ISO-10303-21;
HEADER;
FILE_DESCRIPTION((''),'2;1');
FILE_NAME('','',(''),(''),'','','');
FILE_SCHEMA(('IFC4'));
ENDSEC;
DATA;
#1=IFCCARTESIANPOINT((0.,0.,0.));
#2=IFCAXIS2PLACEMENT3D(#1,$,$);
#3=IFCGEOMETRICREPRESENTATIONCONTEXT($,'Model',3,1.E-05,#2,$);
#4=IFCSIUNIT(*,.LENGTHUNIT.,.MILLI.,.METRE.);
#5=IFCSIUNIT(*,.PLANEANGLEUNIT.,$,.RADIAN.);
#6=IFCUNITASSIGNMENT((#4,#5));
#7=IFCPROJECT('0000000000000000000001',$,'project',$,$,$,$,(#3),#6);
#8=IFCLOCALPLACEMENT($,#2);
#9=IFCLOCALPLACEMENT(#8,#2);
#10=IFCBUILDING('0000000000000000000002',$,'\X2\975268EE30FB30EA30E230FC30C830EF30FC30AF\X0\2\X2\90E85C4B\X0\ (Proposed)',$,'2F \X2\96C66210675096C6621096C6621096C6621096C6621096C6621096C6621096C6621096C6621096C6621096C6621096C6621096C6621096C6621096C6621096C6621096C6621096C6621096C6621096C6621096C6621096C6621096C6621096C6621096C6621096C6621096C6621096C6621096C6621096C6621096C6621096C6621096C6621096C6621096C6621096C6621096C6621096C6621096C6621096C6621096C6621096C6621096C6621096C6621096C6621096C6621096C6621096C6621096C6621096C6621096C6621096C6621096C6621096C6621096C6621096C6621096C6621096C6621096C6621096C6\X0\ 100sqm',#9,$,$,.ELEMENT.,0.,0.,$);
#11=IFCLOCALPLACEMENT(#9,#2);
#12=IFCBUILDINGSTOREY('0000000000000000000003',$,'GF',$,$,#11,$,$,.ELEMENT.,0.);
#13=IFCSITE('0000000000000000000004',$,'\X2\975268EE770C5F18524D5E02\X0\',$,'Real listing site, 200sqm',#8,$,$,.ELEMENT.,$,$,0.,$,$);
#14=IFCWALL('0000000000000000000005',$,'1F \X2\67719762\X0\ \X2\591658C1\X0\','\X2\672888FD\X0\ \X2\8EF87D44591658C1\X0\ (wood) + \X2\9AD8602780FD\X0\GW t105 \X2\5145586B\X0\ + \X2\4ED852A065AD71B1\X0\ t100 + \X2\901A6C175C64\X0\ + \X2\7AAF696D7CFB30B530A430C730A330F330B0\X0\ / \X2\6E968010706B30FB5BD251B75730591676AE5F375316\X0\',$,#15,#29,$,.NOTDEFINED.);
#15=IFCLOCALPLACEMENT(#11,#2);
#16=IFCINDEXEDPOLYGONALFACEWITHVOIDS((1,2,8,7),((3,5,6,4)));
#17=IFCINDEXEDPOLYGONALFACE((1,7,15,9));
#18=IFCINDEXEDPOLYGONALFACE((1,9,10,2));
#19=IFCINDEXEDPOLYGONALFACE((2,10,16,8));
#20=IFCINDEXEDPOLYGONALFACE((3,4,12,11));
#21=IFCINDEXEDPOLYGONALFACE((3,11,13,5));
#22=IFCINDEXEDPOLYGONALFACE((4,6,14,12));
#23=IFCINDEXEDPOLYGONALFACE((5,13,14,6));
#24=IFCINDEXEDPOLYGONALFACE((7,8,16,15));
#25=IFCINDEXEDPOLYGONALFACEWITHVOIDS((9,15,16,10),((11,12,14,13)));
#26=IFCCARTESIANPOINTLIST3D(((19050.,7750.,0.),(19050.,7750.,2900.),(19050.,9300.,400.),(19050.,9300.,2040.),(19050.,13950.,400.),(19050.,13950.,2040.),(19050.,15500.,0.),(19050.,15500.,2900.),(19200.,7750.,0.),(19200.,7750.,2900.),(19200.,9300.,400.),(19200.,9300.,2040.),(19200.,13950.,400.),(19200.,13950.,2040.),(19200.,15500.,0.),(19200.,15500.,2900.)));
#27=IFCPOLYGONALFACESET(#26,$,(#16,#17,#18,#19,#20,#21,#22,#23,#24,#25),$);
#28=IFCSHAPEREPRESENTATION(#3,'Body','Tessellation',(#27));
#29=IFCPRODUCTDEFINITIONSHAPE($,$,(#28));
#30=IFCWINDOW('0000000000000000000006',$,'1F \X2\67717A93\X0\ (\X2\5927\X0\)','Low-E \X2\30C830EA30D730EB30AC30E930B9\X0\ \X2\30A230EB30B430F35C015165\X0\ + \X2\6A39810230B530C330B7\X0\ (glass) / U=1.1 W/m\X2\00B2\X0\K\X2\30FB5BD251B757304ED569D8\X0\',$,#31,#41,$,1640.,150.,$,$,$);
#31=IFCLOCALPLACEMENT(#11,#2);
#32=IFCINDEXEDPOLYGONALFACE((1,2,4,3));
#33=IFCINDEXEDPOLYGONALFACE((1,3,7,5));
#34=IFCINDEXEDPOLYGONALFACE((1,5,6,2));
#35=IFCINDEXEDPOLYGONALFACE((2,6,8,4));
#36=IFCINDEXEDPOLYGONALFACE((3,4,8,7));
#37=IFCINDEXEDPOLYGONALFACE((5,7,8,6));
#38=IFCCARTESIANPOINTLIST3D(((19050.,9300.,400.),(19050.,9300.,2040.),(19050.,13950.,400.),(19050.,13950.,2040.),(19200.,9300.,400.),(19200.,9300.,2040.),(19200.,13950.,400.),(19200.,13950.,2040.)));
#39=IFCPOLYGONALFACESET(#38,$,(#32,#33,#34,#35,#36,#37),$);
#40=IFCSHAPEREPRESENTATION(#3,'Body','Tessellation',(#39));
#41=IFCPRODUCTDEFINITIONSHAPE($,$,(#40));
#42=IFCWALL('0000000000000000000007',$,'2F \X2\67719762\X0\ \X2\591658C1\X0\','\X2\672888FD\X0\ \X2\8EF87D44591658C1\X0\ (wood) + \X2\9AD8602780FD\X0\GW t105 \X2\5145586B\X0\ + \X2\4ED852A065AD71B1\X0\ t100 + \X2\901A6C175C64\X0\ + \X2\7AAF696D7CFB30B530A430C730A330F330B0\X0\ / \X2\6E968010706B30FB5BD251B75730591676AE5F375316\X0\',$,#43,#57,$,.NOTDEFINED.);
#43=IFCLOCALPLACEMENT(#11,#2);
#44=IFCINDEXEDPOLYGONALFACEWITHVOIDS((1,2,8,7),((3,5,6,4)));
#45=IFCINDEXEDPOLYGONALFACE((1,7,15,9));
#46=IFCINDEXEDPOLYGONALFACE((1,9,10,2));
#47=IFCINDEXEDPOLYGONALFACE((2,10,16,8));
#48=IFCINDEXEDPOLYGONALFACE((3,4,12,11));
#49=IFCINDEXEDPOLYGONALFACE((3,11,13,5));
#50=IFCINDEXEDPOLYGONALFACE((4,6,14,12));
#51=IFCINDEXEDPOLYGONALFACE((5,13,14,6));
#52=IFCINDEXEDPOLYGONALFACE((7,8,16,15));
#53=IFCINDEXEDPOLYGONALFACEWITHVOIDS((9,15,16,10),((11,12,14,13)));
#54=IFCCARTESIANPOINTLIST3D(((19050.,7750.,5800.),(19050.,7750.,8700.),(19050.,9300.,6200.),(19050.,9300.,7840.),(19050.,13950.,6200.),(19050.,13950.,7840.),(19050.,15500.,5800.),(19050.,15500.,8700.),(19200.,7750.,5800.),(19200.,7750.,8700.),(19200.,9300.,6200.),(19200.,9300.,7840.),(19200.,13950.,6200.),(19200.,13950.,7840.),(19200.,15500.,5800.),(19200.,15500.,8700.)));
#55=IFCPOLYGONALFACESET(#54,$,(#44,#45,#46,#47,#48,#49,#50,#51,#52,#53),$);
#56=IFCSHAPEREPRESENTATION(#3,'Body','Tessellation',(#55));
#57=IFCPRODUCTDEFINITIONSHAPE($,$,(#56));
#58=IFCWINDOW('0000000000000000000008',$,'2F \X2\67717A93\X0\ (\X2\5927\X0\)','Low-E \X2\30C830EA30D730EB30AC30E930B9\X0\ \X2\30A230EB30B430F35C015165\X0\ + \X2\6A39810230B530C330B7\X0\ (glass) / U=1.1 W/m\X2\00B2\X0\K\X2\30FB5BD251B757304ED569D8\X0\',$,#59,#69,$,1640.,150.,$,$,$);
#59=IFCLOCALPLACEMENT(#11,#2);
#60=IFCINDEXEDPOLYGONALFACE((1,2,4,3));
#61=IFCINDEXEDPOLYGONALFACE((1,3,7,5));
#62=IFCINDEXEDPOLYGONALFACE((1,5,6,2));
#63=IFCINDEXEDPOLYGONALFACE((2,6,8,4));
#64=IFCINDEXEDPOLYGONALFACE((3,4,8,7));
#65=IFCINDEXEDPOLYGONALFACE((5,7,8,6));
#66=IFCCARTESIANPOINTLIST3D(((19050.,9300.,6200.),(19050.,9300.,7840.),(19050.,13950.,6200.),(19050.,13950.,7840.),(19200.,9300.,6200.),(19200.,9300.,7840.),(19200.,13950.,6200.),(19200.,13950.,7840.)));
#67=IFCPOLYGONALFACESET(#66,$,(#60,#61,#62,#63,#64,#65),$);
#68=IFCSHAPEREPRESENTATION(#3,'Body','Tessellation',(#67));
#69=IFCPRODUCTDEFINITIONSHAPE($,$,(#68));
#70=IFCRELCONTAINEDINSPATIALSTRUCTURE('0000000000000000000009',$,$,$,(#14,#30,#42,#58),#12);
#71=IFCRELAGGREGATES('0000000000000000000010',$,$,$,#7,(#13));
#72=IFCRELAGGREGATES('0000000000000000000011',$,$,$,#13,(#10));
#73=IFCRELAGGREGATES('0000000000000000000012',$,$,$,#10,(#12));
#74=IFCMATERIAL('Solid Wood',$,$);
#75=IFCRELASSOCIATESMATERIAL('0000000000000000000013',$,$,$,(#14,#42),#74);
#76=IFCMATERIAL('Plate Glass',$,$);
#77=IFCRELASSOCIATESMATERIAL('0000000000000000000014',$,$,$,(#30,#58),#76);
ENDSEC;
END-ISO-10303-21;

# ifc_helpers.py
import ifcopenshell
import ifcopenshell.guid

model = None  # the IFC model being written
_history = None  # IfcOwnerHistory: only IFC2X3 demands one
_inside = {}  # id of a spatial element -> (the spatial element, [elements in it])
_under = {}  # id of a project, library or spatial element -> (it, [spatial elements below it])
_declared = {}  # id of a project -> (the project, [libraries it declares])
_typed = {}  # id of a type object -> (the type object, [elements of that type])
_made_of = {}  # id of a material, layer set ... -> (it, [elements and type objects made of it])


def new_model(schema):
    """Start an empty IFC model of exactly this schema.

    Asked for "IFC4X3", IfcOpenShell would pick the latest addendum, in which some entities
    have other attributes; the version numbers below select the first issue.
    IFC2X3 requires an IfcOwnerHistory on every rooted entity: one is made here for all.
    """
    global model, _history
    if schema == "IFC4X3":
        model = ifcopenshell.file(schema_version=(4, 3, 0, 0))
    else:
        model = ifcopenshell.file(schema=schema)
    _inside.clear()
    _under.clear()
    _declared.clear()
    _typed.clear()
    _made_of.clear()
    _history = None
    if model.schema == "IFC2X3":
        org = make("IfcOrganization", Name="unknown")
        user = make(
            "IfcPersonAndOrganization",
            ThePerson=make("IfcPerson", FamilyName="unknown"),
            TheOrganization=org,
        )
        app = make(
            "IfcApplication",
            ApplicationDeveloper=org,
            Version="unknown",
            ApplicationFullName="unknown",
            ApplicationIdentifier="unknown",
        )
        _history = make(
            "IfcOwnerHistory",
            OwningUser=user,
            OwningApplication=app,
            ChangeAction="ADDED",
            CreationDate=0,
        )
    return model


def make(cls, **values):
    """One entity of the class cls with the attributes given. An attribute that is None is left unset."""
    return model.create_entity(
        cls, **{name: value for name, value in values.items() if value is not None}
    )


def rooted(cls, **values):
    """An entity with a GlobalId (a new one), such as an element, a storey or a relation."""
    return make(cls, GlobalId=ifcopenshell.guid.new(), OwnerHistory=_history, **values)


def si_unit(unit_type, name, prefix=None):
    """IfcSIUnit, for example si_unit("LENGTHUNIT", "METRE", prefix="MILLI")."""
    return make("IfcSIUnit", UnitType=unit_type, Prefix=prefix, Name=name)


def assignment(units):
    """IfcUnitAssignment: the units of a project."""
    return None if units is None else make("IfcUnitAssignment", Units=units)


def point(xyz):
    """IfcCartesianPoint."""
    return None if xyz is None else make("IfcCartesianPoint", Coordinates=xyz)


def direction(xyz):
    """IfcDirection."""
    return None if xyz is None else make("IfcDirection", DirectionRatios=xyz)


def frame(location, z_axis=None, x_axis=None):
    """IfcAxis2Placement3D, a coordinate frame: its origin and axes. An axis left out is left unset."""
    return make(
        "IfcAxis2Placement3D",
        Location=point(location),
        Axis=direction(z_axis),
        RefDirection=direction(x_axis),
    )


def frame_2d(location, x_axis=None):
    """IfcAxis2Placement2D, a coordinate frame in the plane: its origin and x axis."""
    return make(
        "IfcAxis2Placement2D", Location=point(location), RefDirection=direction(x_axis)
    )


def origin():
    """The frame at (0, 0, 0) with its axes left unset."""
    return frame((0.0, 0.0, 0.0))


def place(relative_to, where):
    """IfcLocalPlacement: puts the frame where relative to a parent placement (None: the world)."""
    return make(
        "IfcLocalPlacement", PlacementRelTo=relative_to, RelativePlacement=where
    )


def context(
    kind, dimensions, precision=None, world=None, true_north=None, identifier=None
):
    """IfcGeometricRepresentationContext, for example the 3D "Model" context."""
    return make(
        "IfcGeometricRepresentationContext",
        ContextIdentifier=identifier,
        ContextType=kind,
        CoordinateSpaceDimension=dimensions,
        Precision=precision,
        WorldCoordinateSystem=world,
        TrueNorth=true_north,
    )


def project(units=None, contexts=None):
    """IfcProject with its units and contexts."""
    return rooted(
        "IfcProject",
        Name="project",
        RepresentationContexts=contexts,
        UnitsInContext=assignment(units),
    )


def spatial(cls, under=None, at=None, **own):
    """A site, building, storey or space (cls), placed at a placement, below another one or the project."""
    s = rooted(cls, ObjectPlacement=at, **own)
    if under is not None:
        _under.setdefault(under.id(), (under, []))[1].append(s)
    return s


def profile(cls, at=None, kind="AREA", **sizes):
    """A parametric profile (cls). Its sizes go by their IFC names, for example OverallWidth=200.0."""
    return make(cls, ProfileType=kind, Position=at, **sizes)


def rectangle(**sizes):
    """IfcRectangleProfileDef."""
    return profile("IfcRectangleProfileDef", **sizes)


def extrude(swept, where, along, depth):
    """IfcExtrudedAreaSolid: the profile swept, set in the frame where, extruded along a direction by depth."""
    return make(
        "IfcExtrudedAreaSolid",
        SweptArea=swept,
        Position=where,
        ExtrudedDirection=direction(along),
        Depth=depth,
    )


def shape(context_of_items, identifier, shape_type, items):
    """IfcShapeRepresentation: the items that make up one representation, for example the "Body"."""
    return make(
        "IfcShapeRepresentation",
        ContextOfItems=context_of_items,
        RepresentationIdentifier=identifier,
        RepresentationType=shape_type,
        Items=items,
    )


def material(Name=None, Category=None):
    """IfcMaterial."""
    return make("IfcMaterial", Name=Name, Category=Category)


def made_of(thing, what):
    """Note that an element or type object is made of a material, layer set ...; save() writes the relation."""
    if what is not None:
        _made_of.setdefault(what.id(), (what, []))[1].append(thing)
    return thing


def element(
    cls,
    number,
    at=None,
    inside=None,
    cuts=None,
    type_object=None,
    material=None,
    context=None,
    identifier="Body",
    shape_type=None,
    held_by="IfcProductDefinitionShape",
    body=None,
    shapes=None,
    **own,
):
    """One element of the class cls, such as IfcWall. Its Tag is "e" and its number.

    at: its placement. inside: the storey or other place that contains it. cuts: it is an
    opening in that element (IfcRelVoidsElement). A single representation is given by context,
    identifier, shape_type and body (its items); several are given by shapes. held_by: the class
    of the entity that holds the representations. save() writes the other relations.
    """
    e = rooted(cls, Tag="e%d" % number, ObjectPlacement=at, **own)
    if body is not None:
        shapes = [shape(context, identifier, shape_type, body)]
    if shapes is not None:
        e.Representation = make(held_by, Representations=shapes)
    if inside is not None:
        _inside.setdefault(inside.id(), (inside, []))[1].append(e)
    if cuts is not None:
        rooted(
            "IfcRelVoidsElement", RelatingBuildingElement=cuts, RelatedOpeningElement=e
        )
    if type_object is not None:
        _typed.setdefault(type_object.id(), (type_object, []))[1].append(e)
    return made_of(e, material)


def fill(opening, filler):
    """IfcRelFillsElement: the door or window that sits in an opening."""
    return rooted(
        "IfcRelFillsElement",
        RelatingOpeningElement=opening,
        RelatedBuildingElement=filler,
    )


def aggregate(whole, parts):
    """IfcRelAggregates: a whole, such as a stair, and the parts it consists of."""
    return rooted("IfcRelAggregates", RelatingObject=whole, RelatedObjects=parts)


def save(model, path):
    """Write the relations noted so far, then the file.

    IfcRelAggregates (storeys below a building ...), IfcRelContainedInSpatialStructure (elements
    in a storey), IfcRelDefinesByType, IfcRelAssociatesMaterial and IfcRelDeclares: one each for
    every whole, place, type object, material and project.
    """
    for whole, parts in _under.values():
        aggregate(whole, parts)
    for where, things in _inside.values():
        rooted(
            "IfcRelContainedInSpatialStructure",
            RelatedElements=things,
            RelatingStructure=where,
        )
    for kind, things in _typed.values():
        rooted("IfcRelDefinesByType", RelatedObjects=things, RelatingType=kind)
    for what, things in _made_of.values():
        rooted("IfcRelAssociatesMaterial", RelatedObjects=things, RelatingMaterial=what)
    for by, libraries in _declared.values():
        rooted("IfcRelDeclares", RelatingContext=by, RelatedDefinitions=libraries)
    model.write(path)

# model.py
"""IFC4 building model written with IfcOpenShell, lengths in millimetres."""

from ifc_helpers import new_model, si_unit, frame, frame_2d, origin, place, context, project, spatial, rectangle, extrude, material, element, fill, save


model = new_model("IFC4")

# Units and contexts
model_context = context("Model", 3, precision=1e-05, world=origin())
ifc_project = project(units=[si_unit("LENGTHUNIT", "METRE", prefix="MILLI"), si_unit("PLANEANGLEUNIT", "RADIAN")], contexts=[model_context])

# Site, building, storey
site_placement = place(None, origin())
site = spatial("IfcSite", under=ifc_project, at=site_placement, Name="青森県弘前市", ObjectType="Real listing site, 200sqm", CompositionType="ELEMENT", RefElevation=0.0)
building_placement = place(site_placement, origin())
building = spatial("IfcBuilding", under=site, at=building_placement, Name="青森・リモートワーク2部屋 (Proposed)", ObjectType="2F 集成材集成集成集成集成集成集成集成集成集成集成集成集成集成集成集成集成集成集成集成集成集成集成集成集成集成集成集成集成集成集成集成集成集成集成集成集成集成集成集成集成集成集成集成集成集成集成集成集成集成集成集成集成集成集成集成集成集成集成集 100sqm", CompositionType="ELEMENT", ElevationOfRefHeight=0.0, ElevationOfTerrain=0.0)
storey_placement = place(building_placement, origin())
storey = spatial("IfcBuildingStorey", under=building, at=storey_placement, Name="GF", CompositionType="ELEMENT", Elevation=0.0)

# Shared definitions
ifc_material_1 = material(Name="Solid Wood")

# Wall, opening, window
wall_1_placement = place(storey_placement, frame((9525.0, 3875.0, 0.0)))
wall_1 = element("IfcWall", 1, at=wall_1_placement, inside=storey, material=ifc_material_1, Name="1F 東面 外壁", Description="木製 軸組外壁 (wood) + 高性能GW t105 充填 + 付加断熱 t100 + 通気層 + 窯業系サイディング / 準耐火・寒冷地外皮強化", PredefinedType="NOTDEFINED", context=model_context, shape_type="SweptSolid", body=[
    extrude(rectangle(XDim=150.0, YDim=7750.0, at=frame_2d((75.0, 3875.0))), frame((9525.0, 3875.0, 0.0)), (0.0, 0.0, 1.0), 2900.0),
])
opening_1_placement = place(storey_placement, frame((9525.0, 4650.0, 200.0)))
opening_1 = element("IfcOpeningElement", 2, at=opening_1_placement, cuts=wall_1, PredefinedType="NOTDEFINED", context=model_context, shape_type="SweptSolid", body=[
    extrude(rectangle(XDim=150.0, YDim=4650.0, at=frame_2d((75.0, 2325.0))), frame((9525.0, 4650.0, 200.0)), (0.0, 0.0, 1.0), 1640.0),
])
ifc_material_2 = material(Name="Plate Glass")
window_1_placement = place(storey_placement, frame((9525.0, 4650.0, 200.0)))
window_1 = element("IfcWindow", 3, at=window_1_placement, inside=storey, material=ifc_material_2, Name="1F 東窓 (大)", Description="Low-E トリプルガラス アルゴン封入 + 樹脂サッシ (glass) / U=1.1 W/m²K・寒冷地仕様", OverallHeight=1640.0, OverallWidth=150.0, context=model_context, shape_type="SweptSolid", body=[
    extrude(rectangle(XDim=150.0, YDim=4650.0, at=frame_2d((75.0, 2325.0))), frame((9525.0, 4650.0, 200.0)), (0.0, 0.0, 1.0), 1640.0),
])
fill(opening_1, window_1)

# Wall, opening, window
wall_2_placement = place(storey_placement, frame((9525.0, 3875.0, 2900.0)))
wall_2 = element("IfcWall", 4, at=wall_2_placement, inside=storey, material=ifc_material_1, Name="2F 東面 外壁", Description="木製 軸組外壁 (wood) + 高性能GW t105 充填 + 付加断熱 t100 + 通気層 + 窯業系サイディング / 準耐火・寒冷地外皮強化", PredefinedType="NOTDEFINED", context=model_context, shape_type="SweptSolid", body=[
    extrude(rectangle(XDim=150.0, YDim=7750.0, at=frame_2d((75.0, 3875.0))), frame((9525.0, 3875.0, 2900.0)), (0.0, 0.0, 1.0), 2900.0),
])
opening_2_placement = place(storey_placement, frame((9525.0, 4650.0, 3100.0)))
opening_2 = element("IfcOpeningElement", 5, at=opening_2_placement, cuts=wall_2, PredefinedType="NOTDEFINED", context=model_context, shape_type="SweptSolid", body=[
    extrude(rectangle(XDim=150.0, YDim=4650.0, at=frame_2d((75.0, 2325.0))), frame((9525.0, 4650.0, 3100.0)), (0.0, 0.0, 1.0), 1640.0),
])
window_2_placement = place(storey_placement, frame((9525.0, 4650.0, 3100.0)))
window_2 = element("IfcWindow", 6, at=window_2_placement, inside=storey, material=ifc_material_2, Name="2F 東窓 (大)", Description="Low-E トリプルガラス アルゴン封入 + 樹脂サッシ (glass) / U=1.1 W/m²K・寒冷地仕様", OverallHeight=1640.0, OverallWidth=150.0, context=model_context, shape_type="SweptSolid", body=[
    extrude(rectangle(XDim=150.0, YDim=4650.0, at=frame_2d((75.0, 2325.0))), frame((9525.0, 4650.0, 3100.0)), (0.0, 0.0, 1.0), 1640.0),
])
fill(opening_2, window_2)

save(model, "model.ifc")
